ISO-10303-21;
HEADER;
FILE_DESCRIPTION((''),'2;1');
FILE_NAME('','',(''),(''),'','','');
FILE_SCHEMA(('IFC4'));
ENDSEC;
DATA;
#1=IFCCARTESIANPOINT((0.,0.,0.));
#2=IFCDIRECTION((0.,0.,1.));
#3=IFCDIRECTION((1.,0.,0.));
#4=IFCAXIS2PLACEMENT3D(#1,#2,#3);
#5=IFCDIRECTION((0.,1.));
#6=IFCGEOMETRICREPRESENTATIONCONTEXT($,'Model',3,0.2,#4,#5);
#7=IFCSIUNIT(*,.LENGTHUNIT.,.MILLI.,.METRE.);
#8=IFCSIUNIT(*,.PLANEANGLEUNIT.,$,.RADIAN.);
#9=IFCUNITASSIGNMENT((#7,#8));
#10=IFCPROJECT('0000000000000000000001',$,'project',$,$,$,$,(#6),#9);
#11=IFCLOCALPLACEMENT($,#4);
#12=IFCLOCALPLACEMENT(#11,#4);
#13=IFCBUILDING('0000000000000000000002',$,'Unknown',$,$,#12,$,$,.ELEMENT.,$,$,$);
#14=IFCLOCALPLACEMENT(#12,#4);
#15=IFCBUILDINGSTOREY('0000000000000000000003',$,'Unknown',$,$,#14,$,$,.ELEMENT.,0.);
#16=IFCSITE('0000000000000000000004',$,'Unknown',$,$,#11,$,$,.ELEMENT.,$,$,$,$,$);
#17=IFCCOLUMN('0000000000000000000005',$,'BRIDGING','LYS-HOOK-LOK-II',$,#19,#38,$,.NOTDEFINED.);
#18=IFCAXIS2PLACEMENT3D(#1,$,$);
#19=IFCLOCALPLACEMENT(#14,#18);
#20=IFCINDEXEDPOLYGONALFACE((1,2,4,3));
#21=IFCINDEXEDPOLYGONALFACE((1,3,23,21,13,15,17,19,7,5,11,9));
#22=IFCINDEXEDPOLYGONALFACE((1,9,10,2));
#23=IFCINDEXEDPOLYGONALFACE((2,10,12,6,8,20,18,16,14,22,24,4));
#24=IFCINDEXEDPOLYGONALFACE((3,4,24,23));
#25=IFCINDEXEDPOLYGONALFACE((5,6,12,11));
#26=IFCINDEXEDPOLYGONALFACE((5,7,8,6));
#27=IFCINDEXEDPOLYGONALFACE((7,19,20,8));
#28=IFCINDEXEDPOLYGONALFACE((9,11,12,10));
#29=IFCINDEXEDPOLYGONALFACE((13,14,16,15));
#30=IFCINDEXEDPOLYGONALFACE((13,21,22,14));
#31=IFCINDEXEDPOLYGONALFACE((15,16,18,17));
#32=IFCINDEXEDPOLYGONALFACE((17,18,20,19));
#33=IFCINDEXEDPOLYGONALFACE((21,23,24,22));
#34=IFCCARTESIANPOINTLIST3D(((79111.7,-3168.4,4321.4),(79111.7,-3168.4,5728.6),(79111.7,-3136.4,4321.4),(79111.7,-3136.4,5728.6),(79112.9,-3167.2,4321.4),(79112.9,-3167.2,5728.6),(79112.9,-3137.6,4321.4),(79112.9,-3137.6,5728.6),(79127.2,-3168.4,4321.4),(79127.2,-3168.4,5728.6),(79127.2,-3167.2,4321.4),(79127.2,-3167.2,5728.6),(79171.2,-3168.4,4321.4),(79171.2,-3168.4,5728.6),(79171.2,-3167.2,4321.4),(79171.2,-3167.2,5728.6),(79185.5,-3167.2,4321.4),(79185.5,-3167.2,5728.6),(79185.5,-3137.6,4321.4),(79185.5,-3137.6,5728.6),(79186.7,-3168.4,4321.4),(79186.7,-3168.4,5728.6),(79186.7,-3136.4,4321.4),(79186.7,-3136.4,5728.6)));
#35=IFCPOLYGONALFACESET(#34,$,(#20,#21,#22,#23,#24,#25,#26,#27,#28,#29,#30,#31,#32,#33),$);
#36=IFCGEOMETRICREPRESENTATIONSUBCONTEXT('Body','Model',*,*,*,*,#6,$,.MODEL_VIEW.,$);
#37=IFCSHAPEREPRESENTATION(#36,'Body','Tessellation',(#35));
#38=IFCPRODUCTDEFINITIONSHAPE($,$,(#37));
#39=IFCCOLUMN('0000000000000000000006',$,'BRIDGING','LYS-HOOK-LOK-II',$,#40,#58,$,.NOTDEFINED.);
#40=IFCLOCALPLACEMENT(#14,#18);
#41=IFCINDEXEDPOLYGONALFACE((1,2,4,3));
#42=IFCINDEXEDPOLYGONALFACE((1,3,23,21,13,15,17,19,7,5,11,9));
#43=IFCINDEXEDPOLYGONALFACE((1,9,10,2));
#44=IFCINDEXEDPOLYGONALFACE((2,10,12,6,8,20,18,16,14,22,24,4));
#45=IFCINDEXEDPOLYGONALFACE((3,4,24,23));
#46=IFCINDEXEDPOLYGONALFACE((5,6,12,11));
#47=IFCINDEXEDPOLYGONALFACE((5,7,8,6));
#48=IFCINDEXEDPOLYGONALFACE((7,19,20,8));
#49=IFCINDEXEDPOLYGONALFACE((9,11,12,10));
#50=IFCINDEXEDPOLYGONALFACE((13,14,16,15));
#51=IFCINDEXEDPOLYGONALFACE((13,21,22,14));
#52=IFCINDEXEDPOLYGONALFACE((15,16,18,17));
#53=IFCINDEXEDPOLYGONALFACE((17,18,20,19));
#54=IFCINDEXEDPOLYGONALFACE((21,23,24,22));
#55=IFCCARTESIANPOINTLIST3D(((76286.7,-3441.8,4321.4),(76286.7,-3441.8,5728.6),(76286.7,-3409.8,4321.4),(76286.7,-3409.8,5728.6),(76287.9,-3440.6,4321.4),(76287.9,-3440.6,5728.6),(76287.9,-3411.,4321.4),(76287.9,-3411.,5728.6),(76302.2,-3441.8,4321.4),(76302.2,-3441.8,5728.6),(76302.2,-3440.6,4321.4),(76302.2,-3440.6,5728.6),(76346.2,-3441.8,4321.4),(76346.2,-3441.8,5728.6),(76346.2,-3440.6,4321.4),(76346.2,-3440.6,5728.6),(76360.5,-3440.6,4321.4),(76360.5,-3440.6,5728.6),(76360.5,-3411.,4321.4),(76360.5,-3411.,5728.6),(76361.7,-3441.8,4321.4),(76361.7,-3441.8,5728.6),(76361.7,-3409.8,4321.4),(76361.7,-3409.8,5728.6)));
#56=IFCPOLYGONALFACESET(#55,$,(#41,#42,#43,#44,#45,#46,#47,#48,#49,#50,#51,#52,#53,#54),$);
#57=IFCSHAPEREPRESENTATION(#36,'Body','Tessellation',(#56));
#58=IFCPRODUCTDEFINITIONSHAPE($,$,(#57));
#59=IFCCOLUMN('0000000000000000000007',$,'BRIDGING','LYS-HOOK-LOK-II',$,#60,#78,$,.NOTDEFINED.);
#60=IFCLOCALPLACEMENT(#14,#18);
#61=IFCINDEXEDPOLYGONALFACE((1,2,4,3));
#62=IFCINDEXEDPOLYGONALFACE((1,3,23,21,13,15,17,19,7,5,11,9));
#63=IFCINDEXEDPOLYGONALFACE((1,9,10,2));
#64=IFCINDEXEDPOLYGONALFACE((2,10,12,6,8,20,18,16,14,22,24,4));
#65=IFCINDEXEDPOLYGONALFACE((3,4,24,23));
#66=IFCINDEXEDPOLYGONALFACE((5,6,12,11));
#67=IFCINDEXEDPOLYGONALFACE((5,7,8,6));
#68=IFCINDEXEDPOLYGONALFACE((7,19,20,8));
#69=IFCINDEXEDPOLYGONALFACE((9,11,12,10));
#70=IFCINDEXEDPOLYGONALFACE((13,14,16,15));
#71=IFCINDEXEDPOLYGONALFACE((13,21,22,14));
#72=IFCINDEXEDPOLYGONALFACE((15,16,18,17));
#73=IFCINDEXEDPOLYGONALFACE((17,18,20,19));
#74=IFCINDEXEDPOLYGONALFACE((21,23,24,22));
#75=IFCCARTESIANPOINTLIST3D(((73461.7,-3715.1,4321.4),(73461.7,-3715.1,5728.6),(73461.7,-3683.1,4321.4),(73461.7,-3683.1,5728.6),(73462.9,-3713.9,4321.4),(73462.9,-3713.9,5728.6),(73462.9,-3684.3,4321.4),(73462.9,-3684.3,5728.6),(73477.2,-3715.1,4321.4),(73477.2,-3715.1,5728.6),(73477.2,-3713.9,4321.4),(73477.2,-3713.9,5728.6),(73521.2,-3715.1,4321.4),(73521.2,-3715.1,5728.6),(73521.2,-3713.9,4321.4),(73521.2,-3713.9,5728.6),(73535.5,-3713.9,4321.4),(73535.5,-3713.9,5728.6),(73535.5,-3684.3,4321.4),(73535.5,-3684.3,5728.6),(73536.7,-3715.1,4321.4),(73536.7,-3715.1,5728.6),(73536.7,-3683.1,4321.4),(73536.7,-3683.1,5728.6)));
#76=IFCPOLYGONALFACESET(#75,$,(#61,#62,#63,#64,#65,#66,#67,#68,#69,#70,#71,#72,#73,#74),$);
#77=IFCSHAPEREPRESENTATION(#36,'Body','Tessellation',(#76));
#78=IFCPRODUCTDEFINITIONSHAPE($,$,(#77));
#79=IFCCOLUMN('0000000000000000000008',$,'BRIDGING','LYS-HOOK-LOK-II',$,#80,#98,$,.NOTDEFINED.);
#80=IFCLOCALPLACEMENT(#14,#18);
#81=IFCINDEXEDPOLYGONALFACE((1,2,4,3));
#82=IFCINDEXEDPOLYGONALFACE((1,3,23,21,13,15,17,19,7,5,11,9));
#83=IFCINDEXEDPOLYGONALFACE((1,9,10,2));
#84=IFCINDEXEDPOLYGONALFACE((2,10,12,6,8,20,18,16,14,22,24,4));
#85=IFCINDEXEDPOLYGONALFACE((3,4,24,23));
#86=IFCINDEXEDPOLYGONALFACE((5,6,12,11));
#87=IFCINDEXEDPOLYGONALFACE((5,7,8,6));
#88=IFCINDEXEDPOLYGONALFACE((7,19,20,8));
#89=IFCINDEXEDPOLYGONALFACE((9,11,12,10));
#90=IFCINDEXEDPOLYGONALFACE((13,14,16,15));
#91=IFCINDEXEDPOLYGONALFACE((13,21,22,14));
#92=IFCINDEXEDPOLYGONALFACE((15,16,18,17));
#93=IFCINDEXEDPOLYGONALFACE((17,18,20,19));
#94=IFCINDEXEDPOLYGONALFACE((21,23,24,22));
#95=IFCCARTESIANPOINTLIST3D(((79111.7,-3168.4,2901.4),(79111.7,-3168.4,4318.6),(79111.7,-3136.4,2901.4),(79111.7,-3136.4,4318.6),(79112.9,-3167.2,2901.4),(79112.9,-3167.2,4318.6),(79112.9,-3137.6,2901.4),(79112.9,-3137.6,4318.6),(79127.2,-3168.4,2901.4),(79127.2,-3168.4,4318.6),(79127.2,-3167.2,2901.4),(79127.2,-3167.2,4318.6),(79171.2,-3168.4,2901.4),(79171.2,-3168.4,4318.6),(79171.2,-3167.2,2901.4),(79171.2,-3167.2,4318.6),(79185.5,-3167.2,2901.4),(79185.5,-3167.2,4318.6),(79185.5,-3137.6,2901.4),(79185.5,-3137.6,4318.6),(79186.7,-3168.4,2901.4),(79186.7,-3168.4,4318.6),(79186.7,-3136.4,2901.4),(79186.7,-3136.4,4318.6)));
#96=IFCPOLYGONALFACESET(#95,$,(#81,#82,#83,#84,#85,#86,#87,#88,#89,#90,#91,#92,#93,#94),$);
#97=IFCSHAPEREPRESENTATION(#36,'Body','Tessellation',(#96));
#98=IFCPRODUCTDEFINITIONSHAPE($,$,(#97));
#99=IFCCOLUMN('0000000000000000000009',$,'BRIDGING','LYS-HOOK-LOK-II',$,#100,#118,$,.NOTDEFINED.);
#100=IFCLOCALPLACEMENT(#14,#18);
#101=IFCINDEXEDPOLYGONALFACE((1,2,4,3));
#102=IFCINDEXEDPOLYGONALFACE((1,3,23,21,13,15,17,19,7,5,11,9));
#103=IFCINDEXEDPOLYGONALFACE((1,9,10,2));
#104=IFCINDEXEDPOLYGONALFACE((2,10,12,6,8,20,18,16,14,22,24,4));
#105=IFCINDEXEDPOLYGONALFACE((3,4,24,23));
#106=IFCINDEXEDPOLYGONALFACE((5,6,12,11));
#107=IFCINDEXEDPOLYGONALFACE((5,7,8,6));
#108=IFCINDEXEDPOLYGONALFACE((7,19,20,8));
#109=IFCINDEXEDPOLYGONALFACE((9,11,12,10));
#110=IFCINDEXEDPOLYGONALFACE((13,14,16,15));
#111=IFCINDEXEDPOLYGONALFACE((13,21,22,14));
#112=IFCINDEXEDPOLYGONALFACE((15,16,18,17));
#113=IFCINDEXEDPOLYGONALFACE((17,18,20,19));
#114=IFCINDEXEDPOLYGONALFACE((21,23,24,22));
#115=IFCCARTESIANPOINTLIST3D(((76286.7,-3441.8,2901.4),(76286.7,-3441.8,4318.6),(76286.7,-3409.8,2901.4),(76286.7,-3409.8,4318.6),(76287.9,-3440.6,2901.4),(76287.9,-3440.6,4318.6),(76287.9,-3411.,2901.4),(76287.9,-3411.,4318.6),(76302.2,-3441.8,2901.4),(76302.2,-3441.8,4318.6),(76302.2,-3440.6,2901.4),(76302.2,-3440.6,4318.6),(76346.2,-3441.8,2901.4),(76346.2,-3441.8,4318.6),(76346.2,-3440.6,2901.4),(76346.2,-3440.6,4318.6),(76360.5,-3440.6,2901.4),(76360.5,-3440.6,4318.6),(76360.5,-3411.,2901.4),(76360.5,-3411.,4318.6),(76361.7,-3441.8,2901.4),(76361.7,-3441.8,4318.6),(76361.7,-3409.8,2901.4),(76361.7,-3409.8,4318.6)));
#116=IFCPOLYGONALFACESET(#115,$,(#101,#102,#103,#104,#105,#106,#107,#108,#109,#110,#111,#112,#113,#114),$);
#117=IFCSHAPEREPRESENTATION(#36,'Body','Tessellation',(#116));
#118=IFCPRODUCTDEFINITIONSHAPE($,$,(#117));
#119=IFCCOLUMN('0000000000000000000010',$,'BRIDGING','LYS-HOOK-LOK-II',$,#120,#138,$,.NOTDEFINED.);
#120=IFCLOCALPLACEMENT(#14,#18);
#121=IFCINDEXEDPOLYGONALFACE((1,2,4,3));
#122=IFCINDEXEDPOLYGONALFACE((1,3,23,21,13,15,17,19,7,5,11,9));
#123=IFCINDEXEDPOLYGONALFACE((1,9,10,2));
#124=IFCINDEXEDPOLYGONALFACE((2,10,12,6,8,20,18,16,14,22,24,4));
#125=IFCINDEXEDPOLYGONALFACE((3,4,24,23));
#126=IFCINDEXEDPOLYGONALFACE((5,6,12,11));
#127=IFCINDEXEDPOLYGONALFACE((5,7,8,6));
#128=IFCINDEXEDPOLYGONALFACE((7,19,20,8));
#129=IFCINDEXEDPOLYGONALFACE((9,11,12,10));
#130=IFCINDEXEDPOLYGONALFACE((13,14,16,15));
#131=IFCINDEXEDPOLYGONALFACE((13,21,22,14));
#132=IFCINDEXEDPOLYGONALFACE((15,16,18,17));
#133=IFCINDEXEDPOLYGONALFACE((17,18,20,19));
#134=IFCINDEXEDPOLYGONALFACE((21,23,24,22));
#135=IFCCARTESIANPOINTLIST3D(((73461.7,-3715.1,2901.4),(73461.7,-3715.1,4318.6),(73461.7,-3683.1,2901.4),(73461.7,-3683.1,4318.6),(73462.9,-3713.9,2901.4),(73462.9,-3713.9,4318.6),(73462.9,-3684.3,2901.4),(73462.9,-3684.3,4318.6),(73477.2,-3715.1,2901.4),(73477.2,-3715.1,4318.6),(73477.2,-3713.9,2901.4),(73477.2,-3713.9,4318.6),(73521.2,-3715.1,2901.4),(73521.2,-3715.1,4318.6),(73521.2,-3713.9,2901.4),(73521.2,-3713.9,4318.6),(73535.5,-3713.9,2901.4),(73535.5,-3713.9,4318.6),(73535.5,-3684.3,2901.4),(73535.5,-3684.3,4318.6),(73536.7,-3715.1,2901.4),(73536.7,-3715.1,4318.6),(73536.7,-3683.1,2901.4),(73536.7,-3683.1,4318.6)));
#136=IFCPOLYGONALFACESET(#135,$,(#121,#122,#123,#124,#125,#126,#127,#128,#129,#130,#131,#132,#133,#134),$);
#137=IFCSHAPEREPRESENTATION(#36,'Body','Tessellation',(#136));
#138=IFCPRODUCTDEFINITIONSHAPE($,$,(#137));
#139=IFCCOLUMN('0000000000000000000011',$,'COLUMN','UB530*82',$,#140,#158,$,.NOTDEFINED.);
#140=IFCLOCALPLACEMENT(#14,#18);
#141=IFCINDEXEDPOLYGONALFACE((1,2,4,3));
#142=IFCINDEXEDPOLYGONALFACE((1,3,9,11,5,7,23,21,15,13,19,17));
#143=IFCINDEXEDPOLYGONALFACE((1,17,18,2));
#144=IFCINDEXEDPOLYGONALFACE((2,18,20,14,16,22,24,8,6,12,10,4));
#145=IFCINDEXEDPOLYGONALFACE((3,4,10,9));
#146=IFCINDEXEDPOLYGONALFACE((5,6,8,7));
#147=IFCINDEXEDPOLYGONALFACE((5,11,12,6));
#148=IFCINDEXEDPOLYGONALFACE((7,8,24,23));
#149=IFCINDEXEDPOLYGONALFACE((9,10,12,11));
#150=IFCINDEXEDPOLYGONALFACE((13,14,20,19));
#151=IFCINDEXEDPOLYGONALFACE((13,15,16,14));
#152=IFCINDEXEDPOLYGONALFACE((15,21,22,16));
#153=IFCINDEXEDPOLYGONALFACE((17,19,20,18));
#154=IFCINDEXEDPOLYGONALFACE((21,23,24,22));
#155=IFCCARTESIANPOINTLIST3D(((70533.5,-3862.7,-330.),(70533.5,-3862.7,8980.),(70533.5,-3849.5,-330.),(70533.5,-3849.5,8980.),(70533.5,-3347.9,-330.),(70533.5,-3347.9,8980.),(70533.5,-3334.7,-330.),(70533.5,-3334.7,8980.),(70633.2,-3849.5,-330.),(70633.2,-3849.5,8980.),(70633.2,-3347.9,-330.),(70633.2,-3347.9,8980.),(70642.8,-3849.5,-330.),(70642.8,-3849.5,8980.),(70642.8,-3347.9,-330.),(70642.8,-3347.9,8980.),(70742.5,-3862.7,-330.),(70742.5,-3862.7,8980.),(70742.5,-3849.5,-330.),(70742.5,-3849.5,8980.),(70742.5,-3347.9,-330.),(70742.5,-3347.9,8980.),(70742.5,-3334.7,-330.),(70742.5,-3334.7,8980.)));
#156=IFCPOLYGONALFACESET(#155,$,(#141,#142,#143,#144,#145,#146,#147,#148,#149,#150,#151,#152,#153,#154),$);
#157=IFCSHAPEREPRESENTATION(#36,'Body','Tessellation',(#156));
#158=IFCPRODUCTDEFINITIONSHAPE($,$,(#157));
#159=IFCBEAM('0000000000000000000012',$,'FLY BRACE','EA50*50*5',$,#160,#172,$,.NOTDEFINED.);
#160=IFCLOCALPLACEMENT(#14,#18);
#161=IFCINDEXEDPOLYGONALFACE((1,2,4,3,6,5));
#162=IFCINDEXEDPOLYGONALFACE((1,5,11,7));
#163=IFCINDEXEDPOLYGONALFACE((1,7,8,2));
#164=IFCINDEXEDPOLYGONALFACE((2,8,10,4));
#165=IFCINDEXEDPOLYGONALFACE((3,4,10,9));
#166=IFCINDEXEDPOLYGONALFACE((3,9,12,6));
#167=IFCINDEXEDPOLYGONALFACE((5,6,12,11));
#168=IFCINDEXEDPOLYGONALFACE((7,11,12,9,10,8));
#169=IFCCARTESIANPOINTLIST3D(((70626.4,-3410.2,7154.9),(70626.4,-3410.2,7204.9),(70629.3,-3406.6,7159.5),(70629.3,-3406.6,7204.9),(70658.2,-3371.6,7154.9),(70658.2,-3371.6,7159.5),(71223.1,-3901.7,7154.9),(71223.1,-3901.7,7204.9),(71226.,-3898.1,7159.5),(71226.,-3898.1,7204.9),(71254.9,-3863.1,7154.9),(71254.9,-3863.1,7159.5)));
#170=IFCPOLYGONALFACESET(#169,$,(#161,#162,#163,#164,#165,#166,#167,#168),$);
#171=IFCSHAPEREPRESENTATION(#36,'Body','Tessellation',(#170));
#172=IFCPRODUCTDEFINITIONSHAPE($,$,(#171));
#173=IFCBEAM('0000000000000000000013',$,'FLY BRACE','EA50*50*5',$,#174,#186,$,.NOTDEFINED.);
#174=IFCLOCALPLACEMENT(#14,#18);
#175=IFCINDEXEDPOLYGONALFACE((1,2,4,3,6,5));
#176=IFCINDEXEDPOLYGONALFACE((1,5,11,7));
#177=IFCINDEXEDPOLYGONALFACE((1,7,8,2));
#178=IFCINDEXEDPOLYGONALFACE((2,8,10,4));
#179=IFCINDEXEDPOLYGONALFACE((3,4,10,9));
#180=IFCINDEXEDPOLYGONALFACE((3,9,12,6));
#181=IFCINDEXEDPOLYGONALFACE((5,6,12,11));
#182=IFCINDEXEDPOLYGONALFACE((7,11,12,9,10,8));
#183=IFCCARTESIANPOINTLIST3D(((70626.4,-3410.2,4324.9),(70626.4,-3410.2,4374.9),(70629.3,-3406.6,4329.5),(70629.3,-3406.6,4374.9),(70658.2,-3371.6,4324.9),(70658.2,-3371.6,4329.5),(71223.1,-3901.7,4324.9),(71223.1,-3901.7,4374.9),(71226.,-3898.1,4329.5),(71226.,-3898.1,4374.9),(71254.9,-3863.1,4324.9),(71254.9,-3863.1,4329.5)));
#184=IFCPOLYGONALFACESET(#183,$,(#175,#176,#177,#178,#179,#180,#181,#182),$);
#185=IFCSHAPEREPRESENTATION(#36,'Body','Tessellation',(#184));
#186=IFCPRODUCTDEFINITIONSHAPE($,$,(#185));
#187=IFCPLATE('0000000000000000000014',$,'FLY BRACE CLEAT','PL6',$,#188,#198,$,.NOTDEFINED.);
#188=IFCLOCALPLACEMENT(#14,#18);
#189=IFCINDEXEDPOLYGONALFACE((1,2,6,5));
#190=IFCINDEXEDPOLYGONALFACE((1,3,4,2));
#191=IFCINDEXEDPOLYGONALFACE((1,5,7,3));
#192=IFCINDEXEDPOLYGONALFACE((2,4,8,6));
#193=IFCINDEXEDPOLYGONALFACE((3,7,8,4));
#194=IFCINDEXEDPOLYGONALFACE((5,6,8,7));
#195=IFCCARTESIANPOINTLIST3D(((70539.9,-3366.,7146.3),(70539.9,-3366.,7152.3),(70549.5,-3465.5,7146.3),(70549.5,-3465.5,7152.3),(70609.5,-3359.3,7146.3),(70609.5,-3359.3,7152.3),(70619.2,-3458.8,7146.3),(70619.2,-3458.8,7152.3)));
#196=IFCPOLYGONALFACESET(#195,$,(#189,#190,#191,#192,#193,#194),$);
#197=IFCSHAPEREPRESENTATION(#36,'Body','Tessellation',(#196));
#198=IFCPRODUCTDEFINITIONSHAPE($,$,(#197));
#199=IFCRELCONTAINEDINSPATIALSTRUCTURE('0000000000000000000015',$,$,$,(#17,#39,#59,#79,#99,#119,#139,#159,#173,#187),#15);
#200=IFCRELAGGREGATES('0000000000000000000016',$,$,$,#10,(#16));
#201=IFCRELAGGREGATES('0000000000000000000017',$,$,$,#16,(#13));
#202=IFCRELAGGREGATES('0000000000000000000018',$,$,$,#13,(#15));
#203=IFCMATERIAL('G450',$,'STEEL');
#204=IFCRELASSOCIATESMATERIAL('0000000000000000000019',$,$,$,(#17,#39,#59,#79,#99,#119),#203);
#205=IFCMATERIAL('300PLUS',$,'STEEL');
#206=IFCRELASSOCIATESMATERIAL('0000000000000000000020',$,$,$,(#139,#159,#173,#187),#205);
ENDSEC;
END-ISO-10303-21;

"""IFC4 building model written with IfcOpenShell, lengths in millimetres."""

from ifc_helpers import new_model, si_unit, direction, frame, origin_with_axes, place, context, subcontext, project, spatial, line, indexed_curve, outline, extrude, material, element, save


model = new_model("IFC4")

# Units and contexts
model_context = context("Model", 3, precision=0.2, world=origin_with_axes(), true_north=direction((0.0, 1.0)))
body_context = subcontext(model_context, "Body", "Model", "MODEL_VIEW")
ifc_project = project(units=[si_unit("LENGTHUNIT", "METRE", prefix="MILLI"), si_unit("PLANEANGLEUNIT", "RADIAN")], contexts=[model_context])

# Site, building, storey
site_placement = place(None, origin_with_axes())
site = spatial("IfcSite", under=ifc_project, at=site_placement, Name="Unknown", CompositionType="ELEMENT")
building_placement = place(site_placement, origin_with_axes())
building = spatial("IfcBuilding", under=site, at=building_placement, Name="Unknown", CompositionType="ELEMENT")
storey_placement = place(building_placement, origin_with_axes())
storey = spatial("IfcBuildingStorey", under=building, at=storey_placement, Name="Unknown", CompositionType="ELEMENT", Elevation=0.0)

# Columns
ifc_material_1 = material(Name="G450", Category="STEEL")
for number, where, z_axis, x_axis, name in (
    (1, (79149.2, -3152.4, 4321.4), (0.0, -1.0, 0.0), (0.0, 0.0, 1.0), "BRIDGING"),
    (2, (76324.2, -3425.8, 4321.4), (0.0, -1.0, 0.0), (0.0, 0.0, 1.0), "BRIDGING"),
    (3, (73499.2, -3699.1, 4321.4), (0.0, -1.0, 0.0), (0.0, 0.0, 1.0), "BRIDGING"),
):
    element("IfcColumn", number, at=place(storey_placement, frame(where, z_axis=z_axis, x_axis=x_axis)), inside=storey, material=ifc_material_1, Name=name, Description="LYS-HOOK-LOK-II", PredefinedType="NOTDEFINED", context=body_context, shape_type="SolidModel", body=[
        extrude(outline(indexed_curve([(16.0, -37.5), (16.0, -22.0), (14.8, -22.0), (14.8, -36.3), (-14.8, -36.3), (-14.8, 36.3), (14.8, 36.3), (14.8, 22.0), (16.0, 22.0), (16.0, 37.5), (-16.0, 37.5), (-16.0, -37.5)], segments=[line(1, 2, 3, 4, 5, 6, 7, 8, 9, 10, 11, 12, 1)])), frame((0.0, 0.0, 0.0), z_axis=(-1.0, 0.0, 0.0), x_axis=(0.0, 0.0, 1.0)), (0.0, 0.0, -1.0), 1407.2),
    ])
for number, where, z_axis, x_axis, name in (
    (4, (79149.2, -3152.4, 2901.4), (0.0, -1.0, 0.0), (0.0, 0.0, 1.0), "BRIDGING"),
    (5, (76324.2, -3425.8, 2901.4), (0.0, -1.0, 0.0), (0.0, 0.0, 1.0), "BRIDGING"),
    (6, (73499.2, -3699.1, 2901.4), (0.0, -1.0, 0.0), (0.0, 0.0, 1.0), "BRIDGING"),
):
    element("IfcColumn", number, at=place(storey_placement, frame(where, z_axis=z_axis, x_axis=x_axis)), inside=storey, material=ifc_material_1, Name=name, Description="LYS-HOOK-LOK-II", PredefinedType="NOTDEFINED", context=body_context, shape_type="SolidModel", body=[
        extrude(outline(indexed_curve([(16.0, -37.5), (16.0, -22.0), (14.8, -22.0), (14.8, -36.3), (-14.8, -36.3), (-14.8, 36.3), (14.8, 36.3), (14.8, 22.0), (16.0, 22.0), (16.0, 37.5), (-16.0, 37.5), (-16.0, -37.5)], segments=[line(1, 2, 3, 4, 5, 6, 7, 8, 9, 10, 11, 12, 1)])), frame((0.0, 0.0, 0.0), z_axis=(-1.0, 0.0, 0.0), x_axis=(0.0, 0.0, 1.0)), (0.0, 0.0, -1.0), 1417.2),
    ])
ifc_material_2 = material(Name="300PLUS", Category="STEEL")
column_placement = place(storey_placement, frame((70638.0, -3598.7, -330.0), z_axis=(-1.0, 0.0, 0.0), x_axis=(0.0, 0.0, 1.0)))
element("IfcColumn", 7, at=column_placement, inside=storey, material=ifc_material_2, Name="COLUMN", Description="UB530*82", PredefinedType="NOTDEFINED", context=body_context, shape_type="SolidModel", body=[
    extrude(outline(indexed_curve([(-104.5, -264.0), (104.5, -264.0), (104.5, -250.8), (4.8, -250.8), (4.8, 250.8), (104.5, 250.8), (104.5, 264.0), (-104.5, 264.0), (-104.5, 250.8), (-4.8, 250.8), (-4.8, -250.8), (-104.5, -250.8)], segments=[line(1, 2, 3, 4, 5, 6, 7, 8, 9, 10, 11, 12, 1)])), frame((0.0, 0.0, 0.0), z_axis=(-1.0, 0.0, 0.0), x_axis=(0.0, 0.0, 1.0)), (0.0, 0.0, -1.0), 9310.0),
])

# Beams
for number, where, z_axis, x_axis, name in (
    (8, (70642.3, -3390.9, 7179.9), (0.0, 0.0, 1.0), (0.771867, -0.635784, 0.0), "FLY BRACE"),
    (9, (70642.3, -3390.9, 4349.9), (0.0, 0.0, 1.0), (0.771867, -0.635784, 0.0), "FLY BRACE"),
):
    element("IfcBeam", number, at=place(storey_placement, frame(where, z_axis=z_axis, x_axis=x_axis)), inside=storey, material=ifc_material_2, Name=name, Description="EA50*50*5", PredefinedType="NOTDEFINED", context=body_context, shape_type="SolidModel", body=[
        extrude(outline(indexed_curve([(-25.0, -25.0), (25.0, -25.0), (25.0, -20.4), (-20.4, -20.4), (-20.4, 25.0), (-25.0, 25.0)], segments=[line(1, 2, 3, 4, 5, 6, 1)])), frame((0.0, 0.0, 0.0), z_axis=(-1.0, 0.0, 0.0), x_axis=(0.0, 0.0, 1.0)), (0.0, 0.0, -1.0), 773.1),
    ])

# Plate
plate_1_placement = place(storey_placement, frame((70609.5, -3359.3, 7149.3), z_axis=(0.0, 0.0, 1.0), x_axis=(-0.995399, -0.095821, 0.0)))
element("IfcPlate", 10, at=plate_1_placement, inside=storey, material=ifc_material_2, Name="FLY BRACE CLEAT", Description="PL6", PredefinedType="NOTDEFINED", context=body_context, shape_type="SolidModel", body=[
    extrude(outline(indexed_curve([(0.0, 0.0), (69.9, 0.0), (69.9, 100.0), (-0.1, 100.0)], segments=[line(1, 2, 3, 4, 1)])), frame((0.0, 0.0, 3.0), z_axis=(0.0, 0.0, 1.0), x_axis=(1.0, 0.0, 0.0)), (0.0, 0.0, -1.0), 6.0),
])

save(model, "model.ifc")
